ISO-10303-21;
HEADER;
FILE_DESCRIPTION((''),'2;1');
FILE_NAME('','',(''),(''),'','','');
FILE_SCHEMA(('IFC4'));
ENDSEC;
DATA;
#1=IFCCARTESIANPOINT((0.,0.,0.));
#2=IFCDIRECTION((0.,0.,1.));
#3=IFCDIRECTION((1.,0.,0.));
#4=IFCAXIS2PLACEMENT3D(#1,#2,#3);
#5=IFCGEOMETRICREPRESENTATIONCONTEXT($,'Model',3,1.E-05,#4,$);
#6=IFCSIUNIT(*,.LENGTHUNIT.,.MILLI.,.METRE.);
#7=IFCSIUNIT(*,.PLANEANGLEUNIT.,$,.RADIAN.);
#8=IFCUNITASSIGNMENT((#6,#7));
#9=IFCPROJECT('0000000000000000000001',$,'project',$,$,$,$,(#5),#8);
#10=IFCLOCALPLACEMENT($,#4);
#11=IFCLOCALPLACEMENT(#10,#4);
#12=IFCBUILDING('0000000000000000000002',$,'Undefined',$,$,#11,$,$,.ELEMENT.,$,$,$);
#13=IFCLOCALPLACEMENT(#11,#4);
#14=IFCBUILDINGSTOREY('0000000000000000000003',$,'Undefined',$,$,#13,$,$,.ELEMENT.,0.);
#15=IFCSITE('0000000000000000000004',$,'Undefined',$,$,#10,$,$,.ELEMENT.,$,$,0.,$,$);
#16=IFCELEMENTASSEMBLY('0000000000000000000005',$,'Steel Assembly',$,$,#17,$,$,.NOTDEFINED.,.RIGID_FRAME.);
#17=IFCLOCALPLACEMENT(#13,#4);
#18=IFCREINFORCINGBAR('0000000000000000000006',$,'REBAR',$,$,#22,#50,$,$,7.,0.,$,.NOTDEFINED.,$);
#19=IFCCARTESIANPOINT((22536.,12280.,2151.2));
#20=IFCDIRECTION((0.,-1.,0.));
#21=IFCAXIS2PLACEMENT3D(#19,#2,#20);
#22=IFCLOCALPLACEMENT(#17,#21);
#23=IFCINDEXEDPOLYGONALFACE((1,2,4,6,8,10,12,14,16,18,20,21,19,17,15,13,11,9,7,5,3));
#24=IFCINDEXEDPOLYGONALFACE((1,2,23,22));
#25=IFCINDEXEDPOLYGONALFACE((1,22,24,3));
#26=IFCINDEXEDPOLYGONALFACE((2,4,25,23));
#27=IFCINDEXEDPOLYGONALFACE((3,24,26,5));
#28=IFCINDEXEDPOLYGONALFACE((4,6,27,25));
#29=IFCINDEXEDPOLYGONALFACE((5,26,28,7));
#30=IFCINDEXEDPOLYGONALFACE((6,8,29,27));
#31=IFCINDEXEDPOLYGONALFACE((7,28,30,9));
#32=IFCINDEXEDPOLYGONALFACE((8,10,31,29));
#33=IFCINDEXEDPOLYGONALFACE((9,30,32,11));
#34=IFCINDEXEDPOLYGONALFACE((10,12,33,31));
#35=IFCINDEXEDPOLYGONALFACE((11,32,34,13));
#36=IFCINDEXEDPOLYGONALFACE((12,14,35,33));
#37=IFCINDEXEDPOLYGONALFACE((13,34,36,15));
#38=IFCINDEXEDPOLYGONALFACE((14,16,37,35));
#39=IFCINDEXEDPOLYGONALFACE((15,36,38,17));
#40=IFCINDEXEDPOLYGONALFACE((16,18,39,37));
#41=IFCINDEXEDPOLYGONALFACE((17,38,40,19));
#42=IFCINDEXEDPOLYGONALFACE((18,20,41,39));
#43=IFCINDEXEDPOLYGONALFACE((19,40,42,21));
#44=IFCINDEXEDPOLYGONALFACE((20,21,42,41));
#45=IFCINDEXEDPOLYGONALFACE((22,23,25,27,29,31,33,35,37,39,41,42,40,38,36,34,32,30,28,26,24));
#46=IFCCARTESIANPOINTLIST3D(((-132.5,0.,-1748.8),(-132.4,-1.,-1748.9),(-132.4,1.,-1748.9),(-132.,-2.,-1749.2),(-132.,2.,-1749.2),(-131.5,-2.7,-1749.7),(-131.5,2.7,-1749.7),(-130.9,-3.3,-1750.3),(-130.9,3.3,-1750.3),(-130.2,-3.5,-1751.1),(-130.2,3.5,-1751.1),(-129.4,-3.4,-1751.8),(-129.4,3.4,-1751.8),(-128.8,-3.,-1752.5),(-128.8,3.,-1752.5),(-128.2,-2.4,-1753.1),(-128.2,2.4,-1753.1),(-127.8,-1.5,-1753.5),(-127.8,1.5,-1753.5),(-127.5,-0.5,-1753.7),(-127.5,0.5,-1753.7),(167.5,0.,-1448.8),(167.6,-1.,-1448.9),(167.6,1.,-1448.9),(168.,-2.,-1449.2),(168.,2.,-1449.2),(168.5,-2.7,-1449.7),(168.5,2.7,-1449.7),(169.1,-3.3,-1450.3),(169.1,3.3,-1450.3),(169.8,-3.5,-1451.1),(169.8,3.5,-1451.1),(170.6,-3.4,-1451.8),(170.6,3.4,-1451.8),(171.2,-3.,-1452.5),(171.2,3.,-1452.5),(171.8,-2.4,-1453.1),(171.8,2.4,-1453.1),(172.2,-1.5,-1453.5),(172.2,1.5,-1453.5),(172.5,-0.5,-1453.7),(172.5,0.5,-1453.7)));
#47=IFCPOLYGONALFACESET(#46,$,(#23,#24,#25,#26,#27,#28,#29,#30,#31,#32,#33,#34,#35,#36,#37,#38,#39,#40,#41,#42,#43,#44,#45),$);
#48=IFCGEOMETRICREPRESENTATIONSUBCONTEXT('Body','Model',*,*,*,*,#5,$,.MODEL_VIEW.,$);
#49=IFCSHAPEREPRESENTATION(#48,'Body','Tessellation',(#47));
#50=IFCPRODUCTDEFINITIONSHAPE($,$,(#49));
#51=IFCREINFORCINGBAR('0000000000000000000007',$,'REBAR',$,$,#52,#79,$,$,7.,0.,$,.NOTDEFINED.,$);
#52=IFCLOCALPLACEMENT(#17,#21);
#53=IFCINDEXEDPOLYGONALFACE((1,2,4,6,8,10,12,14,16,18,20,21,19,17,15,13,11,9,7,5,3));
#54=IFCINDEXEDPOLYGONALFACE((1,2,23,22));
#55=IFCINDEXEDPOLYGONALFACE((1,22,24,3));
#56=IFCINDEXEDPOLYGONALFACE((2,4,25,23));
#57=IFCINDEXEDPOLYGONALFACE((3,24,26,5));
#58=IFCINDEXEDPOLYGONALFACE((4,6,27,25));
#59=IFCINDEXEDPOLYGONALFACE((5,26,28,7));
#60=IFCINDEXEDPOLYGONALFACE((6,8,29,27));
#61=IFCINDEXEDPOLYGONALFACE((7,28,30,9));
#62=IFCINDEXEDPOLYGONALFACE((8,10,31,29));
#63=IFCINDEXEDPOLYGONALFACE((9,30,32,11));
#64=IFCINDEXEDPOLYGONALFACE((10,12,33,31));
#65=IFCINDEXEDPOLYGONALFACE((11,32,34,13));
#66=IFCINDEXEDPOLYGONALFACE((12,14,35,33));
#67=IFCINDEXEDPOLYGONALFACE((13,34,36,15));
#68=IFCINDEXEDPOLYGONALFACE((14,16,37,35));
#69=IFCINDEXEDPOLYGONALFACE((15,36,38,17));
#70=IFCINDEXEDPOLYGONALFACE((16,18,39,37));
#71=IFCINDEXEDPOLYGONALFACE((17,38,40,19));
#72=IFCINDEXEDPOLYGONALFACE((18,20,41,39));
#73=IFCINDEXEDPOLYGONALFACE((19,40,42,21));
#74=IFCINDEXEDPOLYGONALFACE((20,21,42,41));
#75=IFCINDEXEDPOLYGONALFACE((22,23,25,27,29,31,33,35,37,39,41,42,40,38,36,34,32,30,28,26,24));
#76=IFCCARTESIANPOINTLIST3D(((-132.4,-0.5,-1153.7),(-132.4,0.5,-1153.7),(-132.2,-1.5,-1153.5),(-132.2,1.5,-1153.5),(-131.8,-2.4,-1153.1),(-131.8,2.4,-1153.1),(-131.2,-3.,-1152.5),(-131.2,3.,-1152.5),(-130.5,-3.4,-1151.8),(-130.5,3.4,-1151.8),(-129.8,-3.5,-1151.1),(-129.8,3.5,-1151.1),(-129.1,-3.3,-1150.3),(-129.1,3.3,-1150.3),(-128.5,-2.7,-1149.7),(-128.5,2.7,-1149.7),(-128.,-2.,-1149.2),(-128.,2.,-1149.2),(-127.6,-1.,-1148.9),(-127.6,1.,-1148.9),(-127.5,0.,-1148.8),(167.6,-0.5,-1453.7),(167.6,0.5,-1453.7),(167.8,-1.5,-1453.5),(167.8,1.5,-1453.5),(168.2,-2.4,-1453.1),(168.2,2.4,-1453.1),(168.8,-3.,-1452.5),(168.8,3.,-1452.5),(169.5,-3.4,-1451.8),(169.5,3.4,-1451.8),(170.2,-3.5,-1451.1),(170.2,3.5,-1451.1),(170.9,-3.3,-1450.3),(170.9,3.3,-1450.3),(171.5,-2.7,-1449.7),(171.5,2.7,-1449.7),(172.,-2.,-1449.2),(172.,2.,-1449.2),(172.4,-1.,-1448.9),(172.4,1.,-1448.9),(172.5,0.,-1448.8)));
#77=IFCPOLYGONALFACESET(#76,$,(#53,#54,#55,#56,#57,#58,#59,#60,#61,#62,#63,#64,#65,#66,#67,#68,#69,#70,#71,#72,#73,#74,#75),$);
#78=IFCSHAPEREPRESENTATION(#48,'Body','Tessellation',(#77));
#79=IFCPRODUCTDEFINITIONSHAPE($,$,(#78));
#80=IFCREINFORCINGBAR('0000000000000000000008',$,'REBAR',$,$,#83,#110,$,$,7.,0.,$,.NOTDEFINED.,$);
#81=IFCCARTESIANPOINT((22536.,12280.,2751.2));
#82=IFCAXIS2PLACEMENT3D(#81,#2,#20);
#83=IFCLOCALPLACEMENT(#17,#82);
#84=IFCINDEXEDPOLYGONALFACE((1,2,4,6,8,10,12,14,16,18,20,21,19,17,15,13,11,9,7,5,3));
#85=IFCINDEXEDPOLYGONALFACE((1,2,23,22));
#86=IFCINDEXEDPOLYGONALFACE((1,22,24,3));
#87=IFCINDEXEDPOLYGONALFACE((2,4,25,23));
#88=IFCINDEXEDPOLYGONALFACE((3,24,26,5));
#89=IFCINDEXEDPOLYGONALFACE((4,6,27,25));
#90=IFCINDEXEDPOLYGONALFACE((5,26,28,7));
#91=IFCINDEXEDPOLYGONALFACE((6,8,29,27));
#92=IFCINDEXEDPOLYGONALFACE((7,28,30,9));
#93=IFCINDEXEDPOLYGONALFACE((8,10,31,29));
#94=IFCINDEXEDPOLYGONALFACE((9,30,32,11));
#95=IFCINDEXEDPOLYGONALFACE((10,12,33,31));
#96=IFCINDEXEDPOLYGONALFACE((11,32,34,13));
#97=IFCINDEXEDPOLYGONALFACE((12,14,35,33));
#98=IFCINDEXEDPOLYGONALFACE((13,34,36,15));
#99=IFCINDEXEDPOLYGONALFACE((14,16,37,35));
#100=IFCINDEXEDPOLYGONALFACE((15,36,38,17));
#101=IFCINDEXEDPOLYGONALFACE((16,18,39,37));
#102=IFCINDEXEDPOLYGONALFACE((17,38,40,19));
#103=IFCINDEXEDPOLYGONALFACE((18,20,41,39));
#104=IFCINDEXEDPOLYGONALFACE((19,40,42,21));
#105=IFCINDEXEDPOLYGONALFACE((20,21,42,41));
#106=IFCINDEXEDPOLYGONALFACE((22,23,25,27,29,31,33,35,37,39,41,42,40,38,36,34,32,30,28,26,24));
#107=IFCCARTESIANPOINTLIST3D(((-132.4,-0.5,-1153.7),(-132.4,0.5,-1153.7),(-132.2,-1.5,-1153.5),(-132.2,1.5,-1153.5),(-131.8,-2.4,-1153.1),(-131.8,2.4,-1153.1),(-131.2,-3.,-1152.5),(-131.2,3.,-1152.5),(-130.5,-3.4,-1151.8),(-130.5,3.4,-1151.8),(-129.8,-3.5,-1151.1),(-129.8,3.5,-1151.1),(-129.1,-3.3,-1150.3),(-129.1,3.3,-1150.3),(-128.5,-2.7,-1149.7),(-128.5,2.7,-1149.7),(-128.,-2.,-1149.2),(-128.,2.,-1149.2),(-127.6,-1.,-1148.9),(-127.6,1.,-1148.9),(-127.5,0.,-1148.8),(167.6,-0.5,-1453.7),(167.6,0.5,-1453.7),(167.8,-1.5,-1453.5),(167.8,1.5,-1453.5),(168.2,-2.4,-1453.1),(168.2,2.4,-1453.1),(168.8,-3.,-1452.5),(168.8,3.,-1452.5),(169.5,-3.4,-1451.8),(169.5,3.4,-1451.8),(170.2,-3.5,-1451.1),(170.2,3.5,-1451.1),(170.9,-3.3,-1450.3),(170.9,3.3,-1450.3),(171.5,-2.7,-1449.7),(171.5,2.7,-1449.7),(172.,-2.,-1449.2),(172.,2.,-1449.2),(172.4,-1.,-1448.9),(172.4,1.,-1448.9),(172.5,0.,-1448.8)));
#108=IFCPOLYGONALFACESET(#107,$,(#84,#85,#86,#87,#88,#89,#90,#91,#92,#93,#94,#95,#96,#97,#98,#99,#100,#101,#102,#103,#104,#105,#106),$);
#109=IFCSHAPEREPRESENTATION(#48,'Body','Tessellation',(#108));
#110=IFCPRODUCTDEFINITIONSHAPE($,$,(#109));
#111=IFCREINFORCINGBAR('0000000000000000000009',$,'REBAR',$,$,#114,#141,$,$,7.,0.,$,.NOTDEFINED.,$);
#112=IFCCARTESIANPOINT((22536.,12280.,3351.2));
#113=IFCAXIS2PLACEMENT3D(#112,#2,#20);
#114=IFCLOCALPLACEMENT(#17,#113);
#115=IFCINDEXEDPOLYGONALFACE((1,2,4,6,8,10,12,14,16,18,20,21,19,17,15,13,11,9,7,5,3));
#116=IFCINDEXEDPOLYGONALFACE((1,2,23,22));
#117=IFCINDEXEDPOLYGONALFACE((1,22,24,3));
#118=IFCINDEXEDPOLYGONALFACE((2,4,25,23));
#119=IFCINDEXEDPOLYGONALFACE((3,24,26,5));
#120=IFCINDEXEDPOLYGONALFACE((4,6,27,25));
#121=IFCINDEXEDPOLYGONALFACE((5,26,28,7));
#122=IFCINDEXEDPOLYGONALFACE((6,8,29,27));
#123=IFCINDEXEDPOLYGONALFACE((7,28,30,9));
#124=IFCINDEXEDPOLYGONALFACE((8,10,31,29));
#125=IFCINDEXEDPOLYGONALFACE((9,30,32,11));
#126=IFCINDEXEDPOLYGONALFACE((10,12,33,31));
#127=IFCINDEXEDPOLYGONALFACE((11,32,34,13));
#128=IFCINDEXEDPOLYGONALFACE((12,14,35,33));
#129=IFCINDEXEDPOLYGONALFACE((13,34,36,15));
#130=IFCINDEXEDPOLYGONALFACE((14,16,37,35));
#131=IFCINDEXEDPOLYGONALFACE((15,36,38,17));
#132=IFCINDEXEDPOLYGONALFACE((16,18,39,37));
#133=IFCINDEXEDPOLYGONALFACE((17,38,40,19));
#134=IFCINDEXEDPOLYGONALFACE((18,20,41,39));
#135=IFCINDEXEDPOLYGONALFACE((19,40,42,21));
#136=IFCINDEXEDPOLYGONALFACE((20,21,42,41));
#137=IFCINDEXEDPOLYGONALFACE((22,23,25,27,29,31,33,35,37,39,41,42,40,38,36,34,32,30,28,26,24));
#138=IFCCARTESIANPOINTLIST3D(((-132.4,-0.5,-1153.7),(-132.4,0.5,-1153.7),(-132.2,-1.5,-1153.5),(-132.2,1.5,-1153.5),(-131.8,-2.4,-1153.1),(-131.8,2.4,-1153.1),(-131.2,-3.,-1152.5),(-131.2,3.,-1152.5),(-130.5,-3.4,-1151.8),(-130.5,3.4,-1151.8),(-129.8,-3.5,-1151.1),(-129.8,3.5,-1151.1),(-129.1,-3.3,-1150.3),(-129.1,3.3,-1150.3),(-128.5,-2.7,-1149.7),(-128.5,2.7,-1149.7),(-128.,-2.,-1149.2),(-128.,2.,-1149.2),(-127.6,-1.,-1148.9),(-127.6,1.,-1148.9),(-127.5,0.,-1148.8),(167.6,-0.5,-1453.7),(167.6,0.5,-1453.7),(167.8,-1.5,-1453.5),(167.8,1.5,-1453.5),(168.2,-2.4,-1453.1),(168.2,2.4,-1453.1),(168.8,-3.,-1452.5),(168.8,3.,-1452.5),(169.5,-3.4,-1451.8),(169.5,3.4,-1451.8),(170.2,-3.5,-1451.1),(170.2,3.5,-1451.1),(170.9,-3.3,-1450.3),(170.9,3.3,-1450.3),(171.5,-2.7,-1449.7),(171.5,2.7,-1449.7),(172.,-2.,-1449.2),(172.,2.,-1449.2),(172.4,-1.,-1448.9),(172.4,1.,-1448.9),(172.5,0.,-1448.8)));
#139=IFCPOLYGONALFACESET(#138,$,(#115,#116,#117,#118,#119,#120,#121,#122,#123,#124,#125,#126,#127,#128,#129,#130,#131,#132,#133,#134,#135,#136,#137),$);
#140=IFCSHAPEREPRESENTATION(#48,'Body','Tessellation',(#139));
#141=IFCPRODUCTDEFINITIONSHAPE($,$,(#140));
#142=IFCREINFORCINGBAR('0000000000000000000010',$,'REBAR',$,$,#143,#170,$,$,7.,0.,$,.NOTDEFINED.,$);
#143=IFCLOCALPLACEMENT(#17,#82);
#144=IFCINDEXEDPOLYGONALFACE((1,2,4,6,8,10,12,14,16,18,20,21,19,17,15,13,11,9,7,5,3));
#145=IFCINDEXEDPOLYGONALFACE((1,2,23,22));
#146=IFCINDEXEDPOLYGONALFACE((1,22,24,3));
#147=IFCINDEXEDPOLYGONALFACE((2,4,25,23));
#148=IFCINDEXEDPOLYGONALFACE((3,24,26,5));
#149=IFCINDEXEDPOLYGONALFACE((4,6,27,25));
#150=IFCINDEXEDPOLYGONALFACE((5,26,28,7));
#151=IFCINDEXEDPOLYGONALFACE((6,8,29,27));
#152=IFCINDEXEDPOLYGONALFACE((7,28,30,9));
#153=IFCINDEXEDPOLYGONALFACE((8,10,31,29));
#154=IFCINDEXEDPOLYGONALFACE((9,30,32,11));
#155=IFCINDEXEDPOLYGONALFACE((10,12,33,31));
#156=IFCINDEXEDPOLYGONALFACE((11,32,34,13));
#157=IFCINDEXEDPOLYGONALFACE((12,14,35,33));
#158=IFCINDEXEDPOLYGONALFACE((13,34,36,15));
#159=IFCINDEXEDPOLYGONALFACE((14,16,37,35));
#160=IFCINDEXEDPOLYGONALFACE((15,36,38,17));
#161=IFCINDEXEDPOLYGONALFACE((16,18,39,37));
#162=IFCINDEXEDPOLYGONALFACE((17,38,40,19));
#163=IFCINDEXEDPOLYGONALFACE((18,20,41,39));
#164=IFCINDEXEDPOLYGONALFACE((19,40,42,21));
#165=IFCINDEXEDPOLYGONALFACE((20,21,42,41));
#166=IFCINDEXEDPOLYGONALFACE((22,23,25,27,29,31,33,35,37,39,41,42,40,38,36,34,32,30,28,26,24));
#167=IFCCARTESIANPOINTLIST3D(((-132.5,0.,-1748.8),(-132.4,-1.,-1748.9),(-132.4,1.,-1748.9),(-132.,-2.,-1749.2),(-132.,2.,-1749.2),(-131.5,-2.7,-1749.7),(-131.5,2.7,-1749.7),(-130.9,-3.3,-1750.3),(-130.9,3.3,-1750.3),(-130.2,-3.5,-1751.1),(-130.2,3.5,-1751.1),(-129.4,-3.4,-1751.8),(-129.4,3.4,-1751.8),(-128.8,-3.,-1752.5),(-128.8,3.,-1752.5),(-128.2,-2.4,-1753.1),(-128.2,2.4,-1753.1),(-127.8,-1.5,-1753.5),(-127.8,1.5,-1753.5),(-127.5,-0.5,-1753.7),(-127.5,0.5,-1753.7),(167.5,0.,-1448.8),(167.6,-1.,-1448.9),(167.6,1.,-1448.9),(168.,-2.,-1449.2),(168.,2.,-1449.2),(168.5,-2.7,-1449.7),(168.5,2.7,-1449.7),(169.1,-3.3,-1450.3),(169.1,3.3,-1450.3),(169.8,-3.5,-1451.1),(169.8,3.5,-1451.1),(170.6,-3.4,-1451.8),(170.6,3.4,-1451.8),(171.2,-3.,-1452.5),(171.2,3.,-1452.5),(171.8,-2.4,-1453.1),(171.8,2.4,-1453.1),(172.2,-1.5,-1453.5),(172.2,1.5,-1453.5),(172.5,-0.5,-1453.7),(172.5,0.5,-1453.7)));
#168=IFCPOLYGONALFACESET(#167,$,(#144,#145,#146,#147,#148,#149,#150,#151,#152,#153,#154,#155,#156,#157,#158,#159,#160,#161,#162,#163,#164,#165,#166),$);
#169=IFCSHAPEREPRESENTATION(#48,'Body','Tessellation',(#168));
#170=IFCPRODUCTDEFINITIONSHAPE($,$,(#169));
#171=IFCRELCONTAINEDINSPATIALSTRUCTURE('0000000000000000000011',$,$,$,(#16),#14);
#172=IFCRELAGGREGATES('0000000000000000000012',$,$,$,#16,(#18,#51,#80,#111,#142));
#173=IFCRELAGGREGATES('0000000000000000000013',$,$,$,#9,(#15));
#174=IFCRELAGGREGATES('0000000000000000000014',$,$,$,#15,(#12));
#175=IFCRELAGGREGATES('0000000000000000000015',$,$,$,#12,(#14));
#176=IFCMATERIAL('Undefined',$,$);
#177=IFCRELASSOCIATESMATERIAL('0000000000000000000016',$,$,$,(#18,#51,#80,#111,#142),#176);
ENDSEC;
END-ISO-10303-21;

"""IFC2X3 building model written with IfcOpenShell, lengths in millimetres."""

from ifc_helpers import new_model, entity, si_unit, frame, origin_with_axes, place, context, subcontext, project, spatial, source, transform, mapped, material, element, aggregate, save


model = new_model("IFC2X3")

# Units and contexts
model_context = context("Model", 3, precision=1e-05, world=origin_with_axes())
body_context = subcontext(model_context, "Body", "Model", "MODEL_VIEW")
ifc_project = project(units=[si_unit("LENGTHUNIT", "METRE", prefix="MILLI"), si_unit("PLANEANGLEUNIT", "RADIAN")], contexts=[model_context])

# Site, building, storey
site_placement = place(None, origin_with_axes())
site = spatial("IfcSite", under=ifc_project, at=site_placement, Name="Undefined", CompositionType="ELEMENT", RefElevation=0.0)
building_placement = place(site_placement, origin_with_axes())
building = spatial("IfcBuilding", under=site, at=building_placement, Name="Undefined", CompositionType="ELEMENT")
storey_placement = place(building_placement, origin_with_axes())
storey = spatial("IfcBuildingStorey", under=building, at=storey_placement, Name="Undefined", CompositionType="ELEMENT", Elevation=0.0)

# Shared definitions
ifc_material_1 = material(Name="Undefined")

# Element assembly, reinforcing bars
assembly_1_placement = place(storey_placement, origin_with_axes())
assembly_1 = element("IfcElementAssembly", 1, at=assembly_1_placement, inside=storey, Name="Steel Assembly", AssemblyPlace="NOTDEFINED", PredefinedType="RIGID_FRAME")
shared_shape_1 = source(origin_with_axes(), body_context, "Body", "AdvancedSweptSolid", [
    entity("IfcSweptDiskSolid", entity("IfcTrimmedCurve", entity("IfcLine", entity("IfcCartesianPoint", [0.0, 0.0, 0.0]), entity("IfcVector", entity("IfcDirection", [0.707107, 0.0, 0.707107]), 1.0)), [entity("IfcParameterValue", 0.0)], [entity("IfcParameterValue", 424.264069)], True, "PARAMETER"), 3.5, None, 0.0, 424.3),
])
reinforcing_bar_1_placement = place(assembly_1_placement, frame((22536.0, 12280.0, 2151.2), z_axis=(0.0, 0.0, 1.0), x_axis=(0.0, -1.0, 0.0)))
reinforcing_bar_1 = element("IfcReinforcingBar", 2, at=reinforcing_bar_1_placement, material=ifc_material_1, Name="REBAR", BarRole="NOTDEFINED", CrossSectionArea=0.0, NominalDiameter=7.0, context=body_context, shape_type="MappedRepresentation", body=[
    mapped(shared_shape_1, transform((-130.0, 0.0, -1751.2))),
])
shared_shape_2 = source(origin_with_axes(), body_context, "Body", "AdvancedSweptSolid", [
    entity("IfcSweptDiskSolid", entity("IfcTrimmedCurve", entity("IfcLine", entity("IfcCartesianPoint", [0.0, 0.0, 0.0]), entity("IfcVector", entity("IfcDirection", [0.707107, 0.0, -0.707107]), 1.0)), [entity("IfcParameterValue", 0.0)], [entity("IfcParameterValue", 424.264069)], True, "PARAMETER"), 3.5, None, 0.0, 424.3),
])
reinforcing_bar_2_placement = place(assembly_1_placement, frame((22536.0, 12280.0, 2151.2), z_axis=(0.0, 0.0, 1.0), x_axis=(0.0, -1.0, 0.0)))
reinforcing_bar_2 = element("IfcReinforcingBar", 3, at=reinforcing_bar_2_placement, material=ifc_material_1, Name="REBAR", BarRole="NOTDEFINED", CrossSectionArea=0.0, NominalDiameter=7.0, context=body_context, shape_type="MappedRepresentation", body=[
    mapped(shared_shape_2, transform((-130.0, 0.0, -1151.2))),
])
shared_shape_3 = source(origin_with_axes(), body_context, "Body", "AdvancedSweptSolid", [
    entity("IfcSweptDiskSolid", entity("IfcTrimmedCurve", entity("IfcLine", entity("IfcCartesianPoint", [0.0, 0.0, 0.0]), entity("IfcVector", entity("IfcDirection", [0.707107, 0.0, -0.707107]), 1.0)), [entity("IfcParameterValue", 0.0)], [entity("IfcParameterValue", 424.264069)], True, "PARAMETER"), 3.5, None, 0.0, 424.3),
])
reinforcing_bar_3_placement = place(assembly_1_placement, frame((22536.0, 12280.0, 2751.2), z_axis=(0.0, 0.0, 1.0), x_axis=(0.0, -1.0, 0.0)))
reinforcing_bar_3 = element("IfcReinforcingBar", 4, at=reinforcing_bar_3_placement, material=ifc_material_1, Name="REBAR", BarRole="NOTDEFINED", CrossSectionArea=0.0, NominalDiameter=7.0, context=body_context, shape_type="MappedRepresentation", body=[
    mapped(shared_shape_3, transform((-130.0, 0.0, -1151.2))),
])
shared_shape_4 = source(origin_with_axes(), body_context, "Body", "AdvancedSweptSolid", [
    entity("IfcSweptDiskSolid", entity("IfcTrimmedCurve", entity("IfcLine", entity("IfcCartesianPoint", [0.0, 0.0, 0.0]), entity("IfcVector", entity("IfcDirection", [0.707107, 0.0, -0.707107]), 1.0)), [entity("IfcParameterValue", 0.0)], [entity("IfcParameterValue", 424.264069)], True, "PARAMETER"), 3.5, None, 0.0, 424.3),
])
reinforcing_bar_4_placement = place(assembly_1_placement, frame((22536.0, 12280.0, 3351.2), z_axis=(0.0, 0.0, 1.0), x_axis=(0.0, -1.0, 0.0)))
reinforcing_bar_4 = element("IfcReinforcingBar", 5, at=reinforcing_bar_4_placement, material=ifc_material_1, Name="REBAR", BarRole="NOTDEFINED", CrossSectionArea=0.0, NominalDiameter=7.0, context=body_context, shape_type="MappedRepresentation", body=[
    mapped(shared_shape_4, transform((-130.0, 0.0, -1151.2))),
])
shared_shape_5 = source(origin_with_axes(), body_context, "Body", "AdvancedSweptSolid", [
    entity("IfcSweptDiskSolid", entity("IfcTrimmedCurve", entity("IfcLine", entity("IfcCartesianPoint", [0.0, 0.0, 0.0]), entity("IfcVector", entity("IfcDirection", [0.707107, 0.0, 0.707107]), 1.0)), [entity("IfcParameterValue", 0.0)], [entity("IfcParameterValue", 424.264069)], True, "PARAMETER"), 3.5, None, 0.0, 424.3),
])
reinforcing_bar_5_placement = place(assembly_1_placement, frame((22536.0, 12280.0, 2751.2), z_axis=(0.0, 0.0, 1.0), x_axis=(0.0, -1.0, 0.0)))
reinforcing_bar_5 = element("IfcReinforcingBar", 6, at=reinforcing_bar_5_placement, material=ifc_material_1, Name="REBAR", BarRole="NOTDEFINED", CrossSectionArea=0.0, NominalDiameter=7.0, context=body_context, shape_type="MappedRepresentation", body=[
    mapped(shared_shape_5, transform((-130.0, 0.0, -1751.2))),
])
aggregate(assembly_1, [reinforcing_bar_1, reinforcing_bar_2, reinforcing_bar_3, reinforcing_bar_4, reinforcing_bar_5])

save(model, "model.ifc")
